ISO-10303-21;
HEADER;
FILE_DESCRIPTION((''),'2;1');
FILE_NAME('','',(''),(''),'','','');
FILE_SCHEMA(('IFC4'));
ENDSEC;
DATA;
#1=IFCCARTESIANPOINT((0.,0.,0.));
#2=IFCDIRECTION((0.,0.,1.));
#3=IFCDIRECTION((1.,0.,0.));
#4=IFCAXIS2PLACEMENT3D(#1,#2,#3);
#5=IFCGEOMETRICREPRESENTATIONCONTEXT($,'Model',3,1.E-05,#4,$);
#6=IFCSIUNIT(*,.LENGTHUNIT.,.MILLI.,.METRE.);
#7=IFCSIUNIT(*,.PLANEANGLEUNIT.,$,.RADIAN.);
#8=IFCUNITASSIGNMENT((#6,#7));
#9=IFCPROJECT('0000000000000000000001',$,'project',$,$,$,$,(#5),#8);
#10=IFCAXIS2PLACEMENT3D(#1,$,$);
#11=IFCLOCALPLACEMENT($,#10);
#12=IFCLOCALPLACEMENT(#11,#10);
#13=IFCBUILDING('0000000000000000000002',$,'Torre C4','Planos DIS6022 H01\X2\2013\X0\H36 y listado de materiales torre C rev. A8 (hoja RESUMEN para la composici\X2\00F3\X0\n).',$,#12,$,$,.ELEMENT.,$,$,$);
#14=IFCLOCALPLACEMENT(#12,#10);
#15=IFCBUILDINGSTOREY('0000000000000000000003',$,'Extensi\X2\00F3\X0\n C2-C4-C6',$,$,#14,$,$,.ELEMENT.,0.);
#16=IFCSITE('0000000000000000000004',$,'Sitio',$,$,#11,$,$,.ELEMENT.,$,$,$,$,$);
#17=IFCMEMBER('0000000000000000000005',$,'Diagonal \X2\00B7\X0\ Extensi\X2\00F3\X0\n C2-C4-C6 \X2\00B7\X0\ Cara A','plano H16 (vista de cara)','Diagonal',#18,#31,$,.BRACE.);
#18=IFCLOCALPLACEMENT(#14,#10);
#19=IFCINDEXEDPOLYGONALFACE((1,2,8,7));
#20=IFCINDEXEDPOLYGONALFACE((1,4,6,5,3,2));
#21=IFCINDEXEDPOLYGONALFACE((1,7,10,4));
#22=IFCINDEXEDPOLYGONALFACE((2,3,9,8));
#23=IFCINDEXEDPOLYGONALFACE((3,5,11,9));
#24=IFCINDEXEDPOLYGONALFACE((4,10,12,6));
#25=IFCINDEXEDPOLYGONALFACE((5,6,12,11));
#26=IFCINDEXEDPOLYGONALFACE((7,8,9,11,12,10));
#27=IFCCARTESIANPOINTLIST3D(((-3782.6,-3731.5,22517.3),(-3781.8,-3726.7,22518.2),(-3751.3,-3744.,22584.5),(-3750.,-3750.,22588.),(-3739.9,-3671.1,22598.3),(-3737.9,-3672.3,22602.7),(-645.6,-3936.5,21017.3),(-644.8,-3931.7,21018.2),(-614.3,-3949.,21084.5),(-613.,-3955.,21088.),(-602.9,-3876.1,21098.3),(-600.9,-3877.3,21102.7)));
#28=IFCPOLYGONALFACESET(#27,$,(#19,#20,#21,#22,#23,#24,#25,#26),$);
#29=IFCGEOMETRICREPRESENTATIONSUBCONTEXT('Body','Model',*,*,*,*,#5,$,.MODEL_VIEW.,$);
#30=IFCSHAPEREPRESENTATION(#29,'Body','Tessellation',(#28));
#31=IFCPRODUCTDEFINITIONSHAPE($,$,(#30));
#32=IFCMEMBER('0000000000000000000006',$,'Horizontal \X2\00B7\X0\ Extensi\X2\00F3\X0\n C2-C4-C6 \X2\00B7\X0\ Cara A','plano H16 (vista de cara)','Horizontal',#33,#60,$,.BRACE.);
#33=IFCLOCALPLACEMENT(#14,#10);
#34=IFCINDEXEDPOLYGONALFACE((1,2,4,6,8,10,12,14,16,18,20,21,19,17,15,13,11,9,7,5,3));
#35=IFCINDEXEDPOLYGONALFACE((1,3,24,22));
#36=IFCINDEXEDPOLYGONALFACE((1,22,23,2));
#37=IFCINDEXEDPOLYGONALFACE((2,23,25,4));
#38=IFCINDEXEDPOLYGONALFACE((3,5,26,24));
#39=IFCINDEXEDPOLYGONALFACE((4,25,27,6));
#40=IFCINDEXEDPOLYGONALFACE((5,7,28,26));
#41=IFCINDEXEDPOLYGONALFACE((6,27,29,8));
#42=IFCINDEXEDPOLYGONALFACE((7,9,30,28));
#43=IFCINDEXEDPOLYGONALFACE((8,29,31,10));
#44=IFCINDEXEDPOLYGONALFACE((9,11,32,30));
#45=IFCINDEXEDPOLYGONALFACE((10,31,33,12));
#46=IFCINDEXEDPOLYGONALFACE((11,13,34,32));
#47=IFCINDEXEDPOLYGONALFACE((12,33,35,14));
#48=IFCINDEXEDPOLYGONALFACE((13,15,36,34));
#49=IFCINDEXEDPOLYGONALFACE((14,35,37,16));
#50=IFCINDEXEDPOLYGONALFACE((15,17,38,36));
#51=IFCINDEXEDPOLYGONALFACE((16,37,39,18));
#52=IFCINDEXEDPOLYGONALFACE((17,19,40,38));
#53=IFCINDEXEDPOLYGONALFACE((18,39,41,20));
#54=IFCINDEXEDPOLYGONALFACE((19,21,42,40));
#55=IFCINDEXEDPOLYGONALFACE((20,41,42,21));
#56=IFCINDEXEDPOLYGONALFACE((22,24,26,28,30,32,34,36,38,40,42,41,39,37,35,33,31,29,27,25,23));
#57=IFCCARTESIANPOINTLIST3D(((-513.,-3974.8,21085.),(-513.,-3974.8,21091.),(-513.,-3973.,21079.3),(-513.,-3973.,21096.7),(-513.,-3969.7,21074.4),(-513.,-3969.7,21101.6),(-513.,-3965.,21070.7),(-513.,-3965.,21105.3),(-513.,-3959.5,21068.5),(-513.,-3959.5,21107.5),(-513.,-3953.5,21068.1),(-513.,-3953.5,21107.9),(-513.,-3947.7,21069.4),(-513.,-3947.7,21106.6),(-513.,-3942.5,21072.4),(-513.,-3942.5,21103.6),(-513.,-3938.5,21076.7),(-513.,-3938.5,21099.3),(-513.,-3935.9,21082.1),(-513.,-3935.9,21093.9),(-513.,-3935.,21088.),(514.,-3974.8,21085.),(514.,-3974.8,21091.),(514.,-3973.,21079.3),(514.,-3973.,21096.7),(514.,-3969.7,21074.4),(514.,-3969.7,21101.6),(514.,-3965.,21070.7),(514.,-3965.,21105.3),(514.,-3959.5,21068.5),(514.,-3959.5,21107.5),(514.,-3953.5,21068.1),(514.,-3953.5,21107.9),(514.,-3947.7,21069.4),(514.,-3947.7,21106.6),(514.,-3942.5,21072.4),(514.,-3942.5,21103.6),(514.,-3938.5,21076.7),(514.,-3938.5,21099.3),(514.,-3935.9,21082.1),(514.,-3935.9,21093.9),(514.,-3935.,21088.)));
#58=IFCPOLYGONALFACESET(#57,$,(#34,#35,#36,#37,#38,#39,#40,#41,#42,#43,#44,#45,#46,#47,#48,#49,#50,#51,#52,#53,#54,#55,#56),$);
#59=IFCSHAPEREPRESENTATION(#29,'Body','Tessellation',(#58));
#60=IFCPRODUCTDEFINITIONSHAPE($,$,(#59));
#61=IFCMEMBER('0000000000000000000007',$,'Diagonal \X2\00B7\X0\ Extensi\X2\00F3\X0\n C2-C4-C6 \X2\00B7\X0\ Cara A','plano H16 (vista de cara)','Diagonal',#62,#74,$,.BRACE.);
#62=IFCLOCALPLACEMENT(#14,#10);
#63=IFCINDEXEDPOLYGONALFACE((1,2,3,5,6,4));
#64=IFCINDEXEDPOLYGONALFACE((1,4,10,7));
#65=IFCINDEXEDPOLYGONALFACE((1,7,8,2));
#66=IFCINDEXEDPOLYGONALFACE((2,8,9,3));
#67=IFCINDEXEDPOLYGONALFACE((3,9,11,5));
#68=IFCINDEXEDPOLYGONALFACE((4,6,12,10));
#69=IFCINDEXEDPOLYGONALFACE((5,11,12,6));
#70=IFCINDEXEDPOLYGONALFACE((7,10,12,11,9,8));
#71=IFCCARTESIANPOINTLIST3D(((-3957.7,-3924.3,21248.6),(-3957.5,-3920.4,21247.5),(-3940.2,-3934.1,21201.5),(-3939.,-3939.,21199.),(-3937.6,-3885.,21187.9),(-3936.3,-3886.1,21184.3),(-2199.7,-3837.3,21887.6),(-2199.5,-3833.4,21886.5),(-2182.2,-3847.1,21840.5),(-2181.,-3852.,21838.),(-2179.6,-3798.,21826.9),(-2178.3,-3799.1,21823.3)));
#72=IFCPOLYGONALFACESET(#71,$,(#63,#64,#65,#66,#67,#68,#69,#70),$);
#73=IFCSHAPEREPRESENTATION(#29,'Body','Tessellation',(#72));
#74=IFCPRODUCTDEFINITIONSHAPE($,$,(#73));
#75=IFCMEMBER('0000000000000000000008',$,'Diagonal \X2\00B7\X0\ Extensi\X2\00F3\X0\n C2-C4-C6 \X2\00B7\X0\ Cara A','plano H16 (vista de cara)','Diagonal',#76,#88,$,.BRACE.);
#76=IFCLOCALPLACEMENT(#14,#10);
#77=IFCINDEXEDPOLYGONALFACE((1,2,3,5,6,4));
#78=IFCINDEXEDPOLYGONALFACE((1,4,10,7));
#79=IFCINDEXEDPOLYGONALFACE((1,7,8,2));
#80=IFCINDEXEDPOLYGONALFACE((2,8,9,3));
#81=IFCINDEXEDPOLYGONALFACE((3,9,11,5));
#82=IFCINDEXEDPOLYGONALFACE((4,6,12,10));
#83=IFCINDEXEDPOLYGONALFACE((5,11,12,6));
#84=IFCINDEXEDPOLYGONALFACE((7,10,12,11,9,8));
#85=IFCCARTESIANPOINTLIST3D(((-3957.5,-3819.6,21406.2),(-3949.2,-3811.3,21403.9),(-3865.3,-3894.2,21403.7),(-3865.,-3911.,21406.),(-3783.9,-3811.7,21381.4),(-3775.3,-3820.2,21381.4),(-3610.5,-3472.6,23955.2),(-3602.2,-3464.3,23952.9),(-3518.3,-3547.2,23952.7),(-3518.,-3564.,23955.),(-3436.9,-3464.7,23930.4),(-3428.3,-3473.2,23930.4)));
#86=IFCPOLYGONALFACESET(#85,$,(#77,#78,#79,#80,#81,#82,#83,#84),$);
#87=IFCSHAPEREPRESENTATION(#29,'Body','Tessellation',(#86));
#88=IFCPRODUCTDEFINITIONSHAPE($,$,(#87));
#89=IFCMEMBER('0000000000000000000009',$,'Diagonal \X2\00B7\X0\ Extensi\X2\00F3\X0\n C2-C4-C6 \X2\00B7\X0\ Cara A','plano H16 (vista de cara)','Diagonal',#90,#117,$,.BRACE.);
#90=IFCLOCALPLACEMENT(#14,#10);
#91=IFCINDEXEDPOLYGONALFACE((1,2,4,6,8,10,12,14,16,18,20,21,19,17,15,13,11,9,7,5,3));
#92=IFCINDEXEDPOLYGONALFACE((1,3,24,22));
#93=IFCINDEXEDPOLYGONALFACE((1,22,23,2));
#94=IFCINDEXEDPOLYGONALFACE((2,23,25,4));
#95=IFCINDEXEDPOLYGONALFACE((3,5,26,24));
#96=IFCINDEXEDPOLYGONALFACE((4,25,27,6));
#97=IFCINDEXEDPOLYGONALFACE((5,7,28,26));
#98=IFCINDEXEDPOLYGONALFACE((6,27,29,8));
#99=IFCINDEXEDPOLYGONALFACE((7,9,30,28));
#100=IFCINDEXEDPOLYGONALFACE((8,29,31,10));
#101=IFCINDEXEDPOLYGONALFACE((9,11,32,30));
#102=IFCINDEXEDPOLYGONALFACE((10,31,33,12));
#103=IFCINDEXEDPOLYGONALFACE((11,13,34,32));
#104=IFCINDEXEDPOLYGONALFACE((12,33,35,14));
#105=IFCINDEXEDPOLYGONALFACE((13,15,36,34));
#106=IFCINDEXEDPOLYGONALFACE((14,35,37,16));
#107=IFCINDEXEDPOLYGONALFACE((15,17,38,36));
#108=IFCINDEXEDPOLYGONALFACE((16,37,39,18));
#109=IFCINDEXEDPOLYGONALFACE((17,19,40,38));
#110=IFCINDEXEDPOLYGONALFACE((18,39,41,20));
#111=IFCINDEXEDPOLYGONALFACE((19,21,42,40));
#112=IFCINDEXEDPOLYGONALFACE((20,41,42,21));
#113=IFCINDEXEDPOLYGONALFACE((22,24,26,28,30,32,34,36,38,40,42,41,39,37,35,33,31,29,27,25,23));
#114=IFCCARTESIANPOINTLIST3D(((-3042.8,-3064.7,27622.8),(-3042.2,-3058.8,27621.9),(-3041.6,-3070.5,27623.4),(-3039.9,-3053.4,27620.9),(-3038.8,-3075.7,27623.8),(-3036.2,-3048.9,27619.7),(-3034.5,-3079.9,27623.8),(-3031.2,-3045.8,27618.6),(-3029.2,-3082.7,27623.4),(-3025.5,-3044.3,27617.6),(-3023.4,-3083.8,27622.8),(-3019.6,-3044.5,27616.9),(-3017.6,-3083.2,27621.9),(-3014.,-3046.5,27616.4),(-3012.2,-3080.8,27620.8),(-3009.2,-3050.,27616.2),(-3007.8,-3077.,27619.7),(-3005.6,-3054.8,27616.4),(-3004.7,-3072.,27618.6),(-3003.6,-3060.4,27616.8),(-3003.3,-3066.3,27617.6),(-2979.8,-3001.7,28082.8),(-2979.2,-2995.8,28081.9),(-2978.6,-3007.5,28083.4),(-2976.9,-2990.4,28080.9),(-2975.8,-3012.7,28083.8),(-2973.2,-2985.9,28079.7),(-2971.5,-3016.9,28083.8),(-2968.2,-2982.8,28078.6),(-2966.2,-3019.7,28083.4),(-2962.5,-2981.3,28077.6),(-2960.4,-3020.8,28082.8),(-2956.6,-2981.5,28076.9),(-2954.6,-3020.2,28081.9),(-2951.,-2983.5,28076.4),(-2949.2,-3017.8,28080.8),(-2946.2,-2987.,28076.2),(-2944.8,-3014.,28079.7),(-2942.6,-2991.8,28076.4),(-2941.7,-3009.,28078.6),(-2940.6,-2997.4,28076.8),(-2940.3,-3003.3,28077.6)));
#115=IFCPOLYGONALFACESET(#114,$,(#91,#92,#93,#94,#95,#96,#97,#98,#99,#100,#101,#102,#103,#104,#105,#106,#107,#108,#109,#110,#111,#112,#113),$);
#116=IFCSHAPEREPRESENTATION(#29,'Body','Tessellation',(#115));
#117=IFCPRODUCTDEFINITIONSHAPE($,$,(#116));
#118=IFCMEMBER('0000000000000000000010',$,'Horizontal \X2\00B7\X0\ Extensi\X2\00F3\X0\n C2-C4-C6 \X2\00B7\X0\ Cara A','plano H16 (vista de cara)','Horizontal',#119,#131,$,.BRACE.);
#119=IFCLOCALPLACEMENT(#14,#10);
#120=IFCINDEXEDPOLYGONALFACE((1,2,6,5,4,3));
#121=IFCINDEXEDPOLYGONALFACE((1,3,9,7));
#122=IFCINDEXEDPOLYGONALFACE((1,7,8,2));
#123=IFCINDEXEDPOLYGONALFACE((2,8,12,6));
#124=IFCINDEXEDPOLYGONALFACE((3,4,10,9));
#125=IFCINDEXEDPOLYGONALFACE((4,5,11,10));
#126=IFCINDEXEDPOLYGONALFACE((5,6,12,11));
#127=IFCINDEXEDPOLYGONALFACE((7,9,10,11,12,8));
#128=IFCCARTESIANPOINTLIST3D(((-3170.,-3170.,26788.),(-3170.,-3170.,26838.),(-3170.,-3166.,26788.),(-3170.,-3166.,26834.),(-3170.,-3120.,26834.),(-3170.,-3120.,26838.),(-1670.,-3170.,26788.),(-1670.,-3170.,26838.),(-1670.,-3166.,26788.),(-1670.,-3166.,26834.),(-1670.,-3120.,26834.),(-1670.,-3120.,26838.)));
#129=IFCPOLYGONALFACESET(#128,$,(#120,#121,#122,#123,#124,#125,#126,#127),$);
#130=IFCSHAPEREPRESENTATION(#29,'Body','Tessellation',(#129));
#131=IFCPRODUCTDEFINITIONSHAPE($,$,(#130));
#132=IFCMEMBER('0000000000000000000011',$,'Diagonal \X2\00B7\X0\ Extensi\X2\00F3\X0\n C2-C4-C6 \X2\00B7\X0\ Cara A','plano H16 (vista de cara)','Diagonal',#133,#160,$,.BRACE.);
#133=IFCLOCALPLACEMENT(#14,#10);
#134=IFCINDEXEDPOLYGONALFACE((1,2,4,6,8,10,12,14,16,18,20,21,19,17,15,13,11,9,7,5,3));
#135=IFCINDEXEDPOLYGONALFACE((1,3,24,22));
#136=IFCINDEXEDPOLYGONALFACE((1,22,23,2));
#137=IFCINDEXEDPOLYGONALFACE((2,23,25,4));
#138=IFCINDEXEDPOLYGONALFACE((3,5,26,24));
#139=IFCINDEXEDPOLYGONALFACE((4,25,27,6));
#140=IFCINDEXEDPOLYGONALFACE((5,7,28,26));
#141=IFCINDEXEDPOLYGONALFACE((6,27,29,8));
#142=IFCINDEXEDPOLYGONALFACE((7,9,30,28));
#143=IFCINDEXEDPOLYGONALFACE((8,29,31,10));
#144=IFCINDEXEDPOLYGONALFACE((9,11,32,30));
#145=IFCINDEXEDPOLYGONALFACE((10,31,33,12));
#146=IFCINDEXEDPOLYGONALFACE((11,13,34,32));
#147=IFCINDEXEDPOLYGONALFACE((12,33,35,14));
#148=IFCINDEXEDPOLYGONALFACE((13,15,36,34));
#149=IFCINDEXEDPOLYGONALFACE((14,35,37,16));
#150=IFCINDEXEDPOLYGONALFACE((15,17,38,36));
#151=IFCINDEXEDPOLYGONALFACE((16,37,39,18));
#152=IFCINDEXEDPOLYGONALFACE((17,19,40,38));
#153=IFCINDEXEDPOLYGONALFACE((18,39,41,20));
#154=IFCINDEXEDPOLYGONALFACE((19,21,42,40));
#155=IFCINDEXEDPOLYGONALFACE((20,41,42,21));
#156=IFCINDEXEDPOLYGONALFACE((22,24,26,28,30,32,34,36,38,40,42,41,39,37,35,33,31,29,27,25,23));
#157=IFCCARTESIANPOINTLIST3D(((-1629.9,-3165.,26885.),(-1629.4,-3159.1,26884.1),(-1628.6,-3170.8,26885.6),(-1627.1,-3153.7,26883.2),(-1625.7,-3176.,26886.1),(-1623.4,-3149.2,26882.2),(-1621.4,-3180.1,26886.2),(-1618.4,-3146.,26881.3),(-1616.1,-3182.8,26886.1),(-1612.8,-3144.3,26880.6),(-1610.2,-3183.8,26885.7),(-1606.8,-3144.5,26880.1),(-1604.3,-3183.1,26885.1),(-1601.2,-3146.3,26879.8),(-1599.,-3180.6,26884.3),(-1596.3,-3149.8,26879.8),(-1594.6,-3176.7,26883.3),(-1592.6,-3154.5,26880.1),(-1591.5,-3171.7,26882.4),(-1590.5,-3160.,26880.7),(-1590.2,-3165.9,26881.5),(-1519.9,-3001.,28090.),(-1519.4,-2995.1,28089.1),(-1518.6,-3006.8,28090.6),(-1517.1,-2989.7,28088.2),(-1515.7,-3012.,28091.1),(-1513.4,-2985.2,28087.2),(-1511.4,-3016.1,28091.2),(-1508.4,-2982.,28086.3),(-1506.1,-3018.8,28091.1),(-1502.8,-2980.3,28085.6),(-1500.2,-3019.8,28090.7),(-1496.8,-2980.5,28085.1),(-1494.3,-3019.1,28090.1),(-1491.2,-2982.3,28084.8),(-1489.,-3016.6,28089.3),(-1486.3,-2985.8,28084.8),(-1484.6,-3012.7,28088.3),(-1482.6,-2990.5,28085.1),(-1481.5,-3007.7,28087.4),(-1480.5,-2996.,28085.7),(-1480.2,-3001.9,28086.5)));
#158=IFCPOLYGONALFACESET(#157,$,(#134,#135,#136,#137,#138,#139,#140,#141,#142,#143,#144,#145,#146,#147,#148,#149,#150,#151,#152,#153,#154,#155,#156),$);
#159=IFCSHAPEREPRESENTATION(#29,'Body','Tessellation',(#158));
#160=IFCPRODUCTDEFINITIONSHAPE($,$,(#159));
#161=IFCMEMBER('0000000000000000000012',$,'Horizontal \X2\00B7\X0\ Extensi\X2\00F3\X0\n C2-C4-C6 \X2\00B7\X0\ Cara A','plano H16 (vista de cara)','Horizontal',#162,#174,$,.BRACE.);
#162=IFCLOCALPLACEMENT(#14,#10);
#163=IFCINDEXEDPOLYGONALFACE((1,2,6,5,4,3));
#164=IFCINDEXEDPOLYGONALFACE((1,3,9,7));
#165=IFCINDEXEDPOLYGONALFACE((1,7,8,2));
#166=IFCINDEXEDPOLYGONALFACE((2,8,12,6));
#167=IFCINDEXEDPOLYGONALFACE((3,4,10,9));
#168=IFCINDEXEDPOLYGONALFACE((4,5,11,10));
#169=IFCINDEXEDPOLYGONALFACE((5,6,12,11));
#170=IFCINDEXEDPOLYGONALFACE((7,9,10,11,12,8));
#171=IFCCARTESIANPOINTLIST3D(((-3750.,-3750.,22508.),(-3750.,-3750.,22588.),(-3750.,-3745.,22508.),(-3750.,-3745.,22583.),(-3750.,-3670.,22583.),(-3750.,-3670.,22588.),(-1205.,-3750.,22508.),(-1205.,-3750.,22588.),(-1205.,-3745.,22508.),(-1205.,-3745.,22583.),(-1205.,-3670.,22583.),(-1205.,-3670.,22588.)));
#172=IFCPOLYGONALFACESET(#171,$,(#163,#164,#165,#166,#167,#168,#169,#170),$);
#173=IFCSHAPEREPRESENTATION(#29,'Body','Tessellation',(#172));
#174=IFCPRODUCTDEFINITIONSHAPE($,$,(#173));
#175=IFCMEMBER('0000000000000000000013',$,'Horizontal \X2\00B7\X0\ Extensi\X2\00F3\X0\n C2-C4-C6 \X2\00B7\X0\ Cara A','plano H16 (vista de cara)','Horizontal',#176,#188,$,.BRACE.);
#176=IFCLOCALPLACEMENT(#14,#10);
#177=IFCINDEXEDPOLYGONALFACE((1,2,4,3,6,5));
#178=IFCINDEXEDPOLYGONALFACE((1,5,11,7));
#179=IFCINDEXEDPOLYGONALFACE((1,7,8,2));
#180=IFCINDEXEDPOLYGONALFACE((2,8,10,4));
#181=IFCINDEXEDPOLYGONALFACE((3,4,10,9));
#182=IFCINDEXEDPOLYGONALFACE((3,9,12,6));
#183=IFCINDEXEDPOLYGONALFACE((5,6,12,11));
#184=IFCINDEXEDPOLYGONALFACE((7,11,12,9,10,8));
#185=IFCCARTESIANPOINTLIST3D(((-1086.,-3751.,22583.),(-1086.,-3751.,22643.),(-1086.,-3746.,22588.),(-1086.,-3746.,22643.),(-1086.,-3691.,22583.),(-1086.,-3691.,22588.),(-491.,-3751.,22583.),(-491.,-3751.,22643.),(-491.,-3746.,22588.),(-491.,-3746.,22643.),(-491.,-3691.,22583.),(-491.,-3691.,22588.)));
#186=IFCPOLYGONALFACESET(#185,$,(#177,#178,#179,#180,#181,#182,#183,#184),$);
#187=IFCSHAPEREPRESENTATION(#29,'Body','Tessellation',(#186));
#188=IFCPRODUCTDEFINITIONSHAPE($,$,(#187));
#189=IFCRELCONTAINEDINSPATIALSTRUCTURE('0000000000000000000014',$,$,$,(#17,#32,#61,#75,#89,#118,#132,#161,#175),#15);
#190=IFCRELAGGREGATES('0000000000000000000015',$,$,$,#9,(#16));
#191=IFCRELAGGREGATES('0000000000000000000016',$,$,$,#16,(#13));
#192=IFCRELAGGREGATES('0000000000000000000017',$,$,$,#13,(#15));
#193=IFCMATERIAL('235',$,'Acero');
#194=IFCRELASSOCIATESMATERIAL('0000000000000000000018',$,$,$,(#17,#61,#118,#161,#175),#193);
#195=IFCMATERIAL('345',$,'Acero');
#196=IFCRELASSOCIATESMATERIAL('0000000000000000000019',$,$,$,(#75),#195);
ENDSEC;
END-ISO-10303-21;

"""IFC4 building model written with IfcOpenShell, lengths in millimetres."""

from ifc_helpers import new_model, si_unit, frame, frame_2d, origin, origin_with_axes, place, context, subcontext, project, spatial, circle, l_section, extrude, material, element, save


model = new_model("IFC4")

# Units and contexts
model_context = context("Model", 3, precision=1e-05, world=origin_with_axes())
body_context = subcontext(model_context, "Body", "Model", "MODEL_VIEW")
ifc_project = project(units=[si_unit("LENGTHUNIT", "METRE", prefix="MILLI"), si_unit("PLANEANGLEUNIT", "RADIAN")], contexts=[model_context])

# Site, building, storey
site_placement = place(None, origin())
site = spatial("IfcSite", under=ifc_project, at=site_placement, Name="Sitio", CompositionType="ELEMENT")
building_placement = place(site_placement, origin())
building = spatial("IfcBuilding", under=site, at=building_placement, Name="Torre C4", Description="Planos DIS6022 H01–H36 y listado de materiales torre C rev. A8 (hoja RESUMEN para la composición).", CompositionType="ELEMENT")
storey_placement = place(building_placement, origin())
storey = spatial("IfcBuildingStorey", under=building, at=storey_placement, Name="Extensión C2-C4-C6", CompositionType="ELEMENT", Elevation=0.0)

# Members
ifc_material_1 = material(Name="235", Category="Acero")
member_1_placement = place(storey_placement, frame((-613.0, -3955.0, 21088.0), z_axis=(-0.900604, 0.058854, 0.430637), x_axis=(0.151357, 0.971241, 0.183801)))
element("IfcMember", 1, at=member_1_placement, inside=storey, material=ifc_material_1, Name="Diagonal · Extensión C2-C4-C6 · Cara A", Description="plano H16 (vista de cara)", ObjectType="Diagonal", PredefinedType="BRACE", context=body_context, shape_type="SweptSolid", body=[
    extrude(l_section(Depth=80.0, Width=80.0, Thickness=5.0, at=frame_2d((40.0, 40.0))), None, (0.0, 0.0, 1.0), 3483.2),
])
member_2_placement = place(storey_placement, frame((-513.0, -3955.0, 21088.0), z_axis=(1.0, 0.0, 0.0), x_axis=(0.0, 1.0, 0.0)))
element("IfcMember", 2, at=member_2_placement, inside=storey, Name="Horizontal · Extensión C2-C4-C6 · Cara A", Description="plano H16 (vista de cara)", ObjectType="Horizontal", PredefinedType="BRACE", context=body_context, shape_type="SweptSolid", body=[
    extrude(circle(Radius=20.0), None, (0.0, 0.0, 1.0), 1027.0),
])
member_3_placement = place(storey_placement, frame((-3939.0, -3939.0, 21199.0), z_axis=(0.938825, 0.046461, 0.341245), x_axis=(0.049488, 0.962376, -0.267178)))
element("IfcMember", 3, at=member_3_placement, inside=storey, material=ifc_material_1, Name="Diagonal · Extensión C2-C4-C6 · Cara A", Description="plano H16 (vista de cara)", ObjectType="Diagonal", PredefinedType="BRACE", context=body_context, shape_type="SweptSolid", body=[
    extrude(l_section(Depth=55.0, Width=55.0, Thickness=4.0, at=frame_2d((27.5, 27.5))), None, (0.0, 0.0, 1.0), 1872.6),
])
ifc_material_2 = material(Name="345", Category="Acero")
member_4_placement = place(storey_placement, frame((-3865.0, -3911.0, 21406.0), z_axis=(0.133677, 0.133677, 0.981968), x_axis=(0.689884, 0.698801, -0.189044)))
element("IfcMember", 4, at=member_4_placement, inside=storey, material=ifc_material_2, Name="Diagonal · Extensión C2-C4-C6 · Cara A", Description="plano H16 (vista de cara)", ObjectType="Diagonal", PredefinedType="BRACE", context=body_context, shape_type="SweptSolid", body=[
    extrude(l_section(Depth=130.0, Width=130.0, Thickness=12.0, at=frame_2d((65.0, 65.0))), None, (0.0, 0.0, 1.0), 2595.8),
])
member_5_placement = place(storey_placement, frame((-2960.0, -3001.0, 28080.0), z_axis=(-0.134458, -0.134458, -0.981755), x_axis=(0.689287, 0.699091, -0.190147)))
element("IfcMember", 5, at=member_5_placement, inside=storey, Name="Diagonal · Extensión C2-C4-C6 · Cara A", Description="plano H16 (vista de cara)", ObjectType="Diagonal", PredefinedType="BRACE", context=body_context, shape_type="SweptSolid", body=[
    extrude(circle(Radius=20.0), None, (0.0, 0.0, 1.0), 468.5),
])
member_6_placement = place(storey_placement, frame((-1670.0, -3170.0, 26838.0), z_axis=(-1.0, 0.0, 0.0), x_axis=(0.0, 1.0, 0.0)))
element("IfcMember", 6, at=member_6_placement, inside=storey, material=ifc_material_1, Name="Horizontal · Extensión C2-C4-C6 · Cara A", Description="plano H16 (vista de cara)", ObjectType="Horizontal", PredefinedType="BRACE", context=body_context, shape_type="SweptSolid", body=[
    extrude(l_section(Depth=50.0, Width=50.0, Thickness=4.0, at=frame_2d((25.0, 25.0))), None, (0.0, 0.0, 1.0), 1500.0),
])
member_7_placement = place(storey_placement, frame((-1500.0, -3000.0, 28088.0), z_axis=(-0.090085, -0.134308, -0.986836), x_axis=(0.441723, 0.882686, -0.160456)))
element("IfcMember", 7, at=member_7_placement, inside=storey, Name="Diagonal · Extensión C2-C4-C6 · Cara A", Description="plano H16 (vista de cara)", ObjectType="Diagonal", PredefinedType="BRACE", context=body_context, shape_type="SweptSolid", body=[
    extrude(circle(Radius=20.0), None, (0.0, 0.0, 1.0), 1221.1),
])
member_8_placement = place(storey_placement, frame((-1205.0, -3750.0, 22588.0), z_axis=(-1.0, 0.0, 0.0), x_axis=(0.0, 1.0, 0.0)))
element("IfcMember", 8, at=member_8_placement, inside=storey, material=ifc_material_1, Name="Horizontal · Extensión C2-C4-C6 · Cara A", Description="plano H16 (vista de cara)", ObjectType="Horizontal", PredefinedType="BRACE", context=body_context, shape_type="SweptSolid", body=[
    extrude(l_section(Depth=80.0, Width=80.0, Thickness=5.0, at=frame_2d((40.0, 40.0))), None, (0.0, 0.0, 1.0), 2545.0),
])
member_9_placement = place(storey_placement, frame((-1086.0, -3751.0, 22583.0), z_axis=(1.0, 0.0, 0.0), x_axis=(0.0, 1.0, 0.0)))
element("IfcMember", 9, at=member_9_placement, inside=storey, material=ifc_material_1, Name="Horizontal · Extensión C2-C4-C6 · Cara A", Description="plano H16 (vista de cara)", ObjectType="Horizontal", PredefinedType="BRACE", context=body_context, shape_type="SweptSolid", body=[
    extrude(l_section(Depth=60.0, Width=60.0, Thickness=5.0, at=frame_2d((30.0, 30.0))), None, (0.0, 0.0, 1.0), 595.0),
])

save(model, "model.ifc")
